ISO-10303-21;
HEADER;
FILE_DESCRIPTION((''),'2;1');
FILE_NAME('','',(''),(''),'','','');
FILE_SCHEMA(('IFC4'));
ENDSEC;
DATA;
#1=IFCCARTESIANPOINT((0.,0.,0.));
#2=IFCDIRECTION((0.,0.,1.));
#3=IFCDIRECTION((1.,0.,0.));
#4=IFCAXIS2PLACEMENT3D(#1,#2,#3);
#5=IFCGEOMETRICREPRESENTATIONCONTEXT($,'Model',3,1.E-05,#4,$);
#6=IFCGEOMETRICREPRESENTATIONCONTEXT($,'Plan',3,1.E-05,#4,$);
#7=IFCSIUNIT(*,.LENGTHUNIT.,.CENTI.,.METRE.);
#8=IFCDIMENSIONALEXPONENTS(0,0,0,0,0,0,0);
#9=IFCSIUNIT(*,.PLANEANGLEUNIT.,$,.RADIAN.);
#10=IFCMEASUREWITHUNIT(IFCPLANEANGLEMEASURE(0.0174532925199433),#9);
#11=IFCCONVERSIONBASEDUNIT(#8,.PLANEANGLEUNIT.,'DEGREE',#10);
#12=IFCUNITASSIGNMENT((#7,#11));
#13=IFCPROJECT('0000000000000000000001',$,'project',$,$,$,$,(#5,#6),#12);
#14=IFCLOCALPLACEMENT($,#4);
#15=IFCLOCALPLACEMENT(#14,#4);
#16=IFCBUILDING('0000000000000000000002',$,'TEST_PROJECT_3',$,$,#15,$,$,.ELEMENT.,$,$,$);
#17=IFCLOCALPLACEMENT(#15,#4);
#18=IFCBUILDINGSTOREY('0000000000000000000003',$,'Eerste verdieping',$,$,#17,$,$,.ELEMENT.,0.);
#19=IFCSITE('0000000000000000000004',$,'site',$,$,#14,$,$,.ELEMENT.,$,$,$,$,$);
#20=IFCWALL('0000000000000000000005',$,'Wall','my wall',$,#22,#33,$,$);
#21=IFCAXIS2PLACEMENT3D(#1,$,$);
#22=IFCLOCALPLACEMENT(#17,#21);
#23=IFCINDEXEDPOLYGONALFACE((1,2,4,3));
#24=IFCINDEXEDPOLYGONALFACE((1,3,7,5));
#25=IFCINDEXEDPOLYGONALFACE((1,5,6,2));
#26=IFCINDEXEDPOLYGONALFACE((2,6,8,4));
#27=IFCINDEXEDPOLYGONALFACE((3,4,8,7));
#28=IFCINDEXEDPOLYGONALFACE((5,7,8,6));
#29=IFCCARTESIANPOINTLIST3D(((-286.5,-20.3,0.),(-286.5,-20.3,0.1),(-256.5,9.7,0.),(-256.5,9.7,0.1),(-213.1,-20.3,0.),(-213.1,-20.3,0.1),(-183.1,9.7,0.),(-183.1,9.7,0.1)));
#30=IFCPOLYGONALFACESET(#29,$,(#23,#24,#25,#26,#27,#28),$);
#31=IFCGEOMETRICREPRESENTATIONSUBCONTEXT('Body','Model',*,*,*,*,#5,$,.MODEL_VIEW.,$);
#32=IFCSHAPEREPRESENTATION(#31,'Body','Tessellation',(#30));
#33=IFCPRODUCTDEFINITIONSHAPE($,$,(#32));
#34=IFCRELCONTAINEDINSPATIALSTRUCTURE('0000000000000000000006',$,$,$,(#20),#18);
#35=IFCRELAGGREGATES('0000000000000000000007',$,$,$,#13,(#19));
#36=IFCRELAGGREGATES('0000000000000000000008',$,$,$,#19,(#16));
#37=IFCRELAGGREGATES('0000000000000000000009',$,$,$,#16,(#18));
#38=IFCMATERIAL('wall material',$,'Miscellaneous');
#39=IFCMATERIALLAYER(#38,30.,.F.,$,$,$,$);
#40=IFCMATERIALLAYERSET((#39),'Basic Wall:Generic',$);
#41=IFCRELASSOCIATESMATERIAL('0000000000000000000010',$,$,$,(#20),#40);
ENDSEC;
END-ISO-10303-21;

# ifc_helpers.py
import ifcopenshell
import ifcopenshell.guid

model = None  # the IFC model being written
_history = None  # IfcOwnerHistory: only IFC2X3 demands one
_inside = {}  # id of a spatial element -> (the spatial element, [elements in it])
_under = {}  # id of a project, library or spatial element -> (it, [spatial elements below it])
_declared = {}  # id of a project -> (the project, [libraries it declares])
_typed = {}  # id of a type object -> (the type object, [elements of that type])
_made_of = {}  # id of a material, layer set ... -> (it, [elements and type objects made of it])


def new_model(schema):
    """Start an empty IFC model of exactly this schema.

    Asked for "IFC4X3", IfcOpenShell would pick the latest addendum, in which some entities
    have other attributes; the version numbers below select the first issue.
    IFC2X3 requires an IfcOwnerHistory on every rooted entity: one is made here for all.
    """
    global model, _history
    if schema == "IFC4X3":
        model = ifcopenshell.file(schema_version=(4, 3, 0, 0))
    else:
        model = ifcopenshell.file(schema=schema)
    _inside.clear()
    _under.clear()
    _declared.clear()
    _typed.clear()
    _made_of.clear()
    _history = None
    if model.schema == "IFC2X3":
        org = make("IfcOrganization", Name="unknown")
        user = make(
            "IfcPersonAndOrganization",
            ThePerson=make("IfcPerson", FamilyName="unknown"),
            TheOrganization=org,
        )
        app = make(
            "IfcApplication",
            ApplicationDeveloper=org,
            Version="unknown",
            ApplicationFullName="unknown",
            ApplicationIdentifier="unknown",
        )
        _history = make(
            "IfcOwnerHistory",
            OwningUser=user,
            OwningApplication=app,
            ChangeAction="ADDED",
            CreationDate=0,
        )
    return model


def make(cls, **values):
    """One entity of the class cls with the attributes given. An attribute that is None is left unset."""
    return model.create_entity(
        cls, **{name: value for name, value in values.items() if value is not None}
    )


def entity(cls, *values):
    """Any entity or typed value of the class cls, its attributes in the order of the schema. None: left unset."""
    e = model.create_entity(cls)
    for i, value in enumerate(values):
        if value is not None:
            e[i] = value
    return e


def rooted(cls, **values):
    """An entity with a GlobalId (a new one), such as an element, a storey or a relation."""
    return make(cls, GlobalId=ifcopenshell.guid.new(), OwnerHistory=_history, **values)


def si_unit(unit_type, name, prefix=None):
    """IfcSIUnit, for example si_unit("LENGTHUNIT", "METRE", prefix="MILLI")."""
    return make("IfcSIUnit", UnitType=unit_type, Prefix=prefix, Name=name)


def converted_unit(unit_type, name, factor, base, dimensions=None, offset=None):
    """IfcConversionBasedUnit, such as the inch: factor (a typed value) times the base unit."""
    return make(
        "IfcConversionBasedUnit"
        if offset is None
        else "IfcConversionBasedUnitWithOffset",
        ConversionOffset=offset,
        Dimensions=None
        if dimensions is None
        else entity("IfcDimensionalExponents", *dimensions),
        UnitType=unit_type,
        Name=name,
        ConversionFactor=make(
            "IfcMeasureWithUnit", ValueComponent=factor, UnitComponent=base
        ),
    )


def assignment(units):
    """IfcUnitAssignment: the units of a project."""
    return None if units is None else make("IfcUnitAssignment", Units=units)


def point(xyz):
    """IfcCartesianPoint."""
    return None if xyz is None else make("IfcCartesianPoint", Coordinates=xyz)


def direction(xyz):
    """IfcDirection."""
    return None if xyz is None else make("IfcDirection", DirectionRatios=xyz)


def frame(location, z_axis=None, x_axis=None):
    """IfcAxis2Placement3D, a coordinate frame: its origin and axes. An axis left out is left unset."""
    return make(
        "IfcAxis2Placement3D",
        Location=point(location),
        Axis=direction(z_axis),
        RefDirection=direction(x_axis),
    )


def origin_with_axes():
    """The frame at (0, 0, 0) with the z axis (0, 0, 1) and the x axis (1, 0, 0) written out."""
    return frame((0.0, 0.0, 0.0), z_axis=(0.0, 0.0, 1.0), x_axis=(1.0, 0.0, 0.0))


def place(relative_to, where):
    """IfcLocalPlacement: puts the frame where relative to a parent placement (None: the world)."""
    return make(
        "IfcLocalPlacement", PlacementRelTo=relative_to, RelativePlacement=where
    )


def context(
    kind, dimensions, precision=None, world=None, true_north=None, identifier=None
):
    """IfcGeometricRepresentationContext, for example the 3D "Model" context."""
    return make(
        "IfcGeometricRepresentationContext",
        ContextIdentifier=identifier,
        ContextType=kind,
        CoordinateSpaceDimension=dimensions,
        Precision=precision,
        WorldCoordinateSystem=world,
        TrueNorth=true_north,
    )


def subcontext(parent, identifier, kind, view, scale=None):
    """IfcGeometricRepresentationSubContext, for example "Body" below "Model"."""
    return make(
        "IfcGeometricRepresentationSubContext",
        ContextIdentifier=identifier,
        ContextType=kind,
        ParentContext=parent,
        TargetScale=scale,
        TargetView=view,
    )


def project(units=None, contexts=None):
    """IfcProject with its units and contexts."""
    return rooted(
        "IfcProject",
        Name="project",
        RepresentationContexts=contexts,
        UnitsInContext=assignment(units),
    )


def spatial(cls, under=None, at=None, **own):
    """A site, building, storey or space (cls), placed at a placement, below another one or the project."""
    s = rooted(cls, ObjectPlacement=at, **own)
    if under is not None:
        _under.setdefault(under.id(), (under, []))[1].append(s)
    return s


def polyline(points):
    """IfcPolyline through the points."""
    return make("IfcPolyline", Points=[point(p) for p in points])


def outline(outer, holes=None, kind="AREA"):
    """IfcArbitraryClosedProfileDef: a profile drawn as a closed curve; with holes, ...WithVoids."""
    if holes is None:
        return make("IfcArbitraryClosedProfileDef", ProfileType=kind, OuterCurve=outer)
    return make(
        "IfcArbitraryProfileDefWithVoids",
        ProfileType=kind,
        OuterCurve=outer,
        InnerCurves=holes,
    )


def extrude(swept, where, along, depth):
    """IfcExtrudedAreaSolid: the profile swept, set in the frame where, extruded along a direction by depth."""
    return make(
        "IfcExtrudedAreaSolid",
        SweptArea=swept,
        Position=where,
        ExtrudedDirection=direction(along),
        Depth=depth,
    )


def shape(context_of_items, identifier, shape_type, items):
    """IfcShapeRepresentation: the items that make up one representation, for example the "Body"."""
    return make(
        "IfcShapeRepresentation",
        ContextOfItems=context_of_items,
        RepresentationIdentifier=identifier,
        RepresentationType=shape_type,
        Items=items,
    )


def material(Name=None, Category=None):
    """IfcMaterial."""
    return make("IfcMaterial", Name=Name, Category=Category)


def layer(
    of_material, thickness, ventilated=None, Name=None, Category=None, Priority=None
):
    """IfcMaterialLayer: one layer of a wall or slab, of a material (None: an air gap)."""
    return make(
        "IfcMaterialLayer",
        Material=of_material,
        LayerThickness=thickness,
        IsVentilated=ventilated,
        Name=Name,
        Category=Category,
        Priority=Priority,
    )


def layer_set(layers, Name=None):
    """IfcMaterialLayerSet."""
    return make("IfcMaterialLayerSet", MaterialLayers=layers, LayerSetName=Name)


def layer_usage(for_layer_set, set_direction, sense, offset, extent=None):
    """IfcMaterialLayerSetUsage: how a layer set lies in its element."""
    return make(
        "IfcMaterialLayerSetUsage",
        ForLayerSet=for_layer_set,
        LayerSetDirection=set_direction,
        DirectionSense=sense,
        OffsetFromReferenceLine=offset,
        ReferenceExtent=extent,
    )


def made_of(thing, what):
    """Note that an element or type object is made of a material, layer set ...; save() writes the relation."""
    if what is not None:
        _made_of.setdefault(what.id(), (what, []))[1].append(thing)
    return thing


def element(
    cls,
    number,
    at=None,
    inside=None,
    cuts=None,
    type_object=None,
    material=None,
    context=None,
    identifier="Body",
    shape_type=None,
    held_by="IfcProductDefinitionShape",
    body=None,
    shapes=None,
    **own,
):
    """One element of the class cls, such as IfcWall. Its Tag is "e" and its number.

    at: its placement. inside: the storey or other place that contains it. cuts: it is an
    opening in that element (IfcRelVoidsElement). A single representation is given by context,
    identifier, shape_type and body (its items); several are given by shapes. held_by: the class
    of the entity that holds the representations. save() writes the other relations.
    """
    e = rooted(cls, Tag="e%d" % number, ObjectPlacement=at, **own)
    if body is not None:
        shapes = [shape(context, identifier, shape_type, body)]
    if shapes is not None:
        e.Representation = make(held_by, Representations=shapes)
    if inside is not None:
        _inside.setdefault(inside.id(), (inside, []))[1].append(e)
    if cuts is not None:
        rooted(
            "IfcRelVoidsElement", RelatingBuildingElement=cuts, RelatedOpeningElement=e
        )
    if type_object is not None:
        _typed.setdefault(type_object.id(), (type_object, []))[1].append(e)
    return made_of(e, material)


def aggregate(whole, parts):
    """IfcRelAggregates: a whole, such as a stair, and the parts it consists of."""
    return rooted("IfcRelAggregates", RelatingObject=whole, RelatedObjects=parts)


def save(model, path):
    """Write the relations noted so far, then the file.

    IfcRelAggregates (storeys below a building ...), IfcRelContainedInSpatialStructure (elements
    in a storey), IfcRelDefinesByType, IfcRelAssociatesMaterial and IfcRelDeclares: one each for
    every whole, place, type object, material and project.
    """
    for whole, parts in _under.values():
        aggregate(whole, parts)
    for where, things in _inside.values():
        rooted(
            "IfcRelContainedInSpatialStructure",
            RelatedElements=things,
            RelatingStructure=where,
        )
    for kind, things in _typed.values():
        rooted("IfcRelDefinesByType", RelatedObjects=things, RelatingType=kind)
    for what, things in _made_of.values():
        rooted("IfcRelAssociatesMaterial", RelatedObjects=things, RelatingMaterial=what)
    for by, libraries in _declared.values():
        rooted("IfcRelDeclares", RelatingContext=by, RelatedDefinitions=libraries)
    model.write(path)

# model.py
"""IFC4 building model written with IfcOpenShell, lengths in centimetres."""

from ifc_helpers import new_model, entity, si_unit, converted_unit, origin_with_axes, place, context, subcontext, project, spatial, polyline, outline, extrude, material, layer, layer_set, layer_usage, element, save


model = new_model("IFC4")

# Units and contexts
model_context = context("Model", 3, precision=1e-05, world=origin_with_axes())
plan_context = context("Plan", 3, precision=1e-05, world=origin_with_axes())
body_context = subcontext(model_context, "Body", "Model", "MODEL_VIEW")
ifc_project = project(units=[si_unit("LENGTHUNIT", "METRE", prefix="CENTI"), converted_unit("PLANEANGLEUNIT", "DEGREE", entity("IfcPlaneAngleMeasure", 0.0174532925199433), si_unit("PLANEANGLEUNIT", "RADIAN"), dimensions=[0, 0, 0, 0, 0, 0, 0])], contexts=[model_context, plan_context])

# Site, building, storey
site_placement = place(None, origin_with_axes())
site = spatial("IfcSite", under=ifc_project, at=site_placement, Name="site", CompositionType="ELEMENT")
building_placement = place(site_placement, origin_with_axes())
building = spatial("IfcBuilding", under=site, at=building_placement, Name="TEST_PROJECT_3", CompositionType="ELEMENT")
storey_placement = place(building_placement, origin_with_axes())
storey = spatial("IfcBuildingStorey", under=building, at=storey_placement, Name="Eerste verdieping", CompositionType="ELEMENT", Elevation=0.0)

# Wall
ifc_material_1 = material(Name="wall material", Category="Miscellaneous")
ifc_layer_1 = layer(ifc_material_1, 30.0, ventilated=False)
ifc_layer_set_1 = layer_set([ifc_layer_1], Name="Basic Wall:Generic")
ifc_layer_usage_1 = layer_usage(ifc_layer_set_1, "AXIS3", "NEGATIVE", 0.0)
wall_1_placement = place(storey_placement, origin_with_axes())
element("IfcWall", 1, at=wall_1_placement, inside=storey, material=ifc_layer_usage_1, Name="Wall", Description="my wall", context=body_context, shape_type="SweptSolid", body=[
    extrude(outline(polyline([(-286.5, -20.3, 0.0), (-256.5, 9.7, 0.0), (-183.1, 9.7, 0.0), (-213.1, -20.3, 0.0), (-286.5, -20.3, 0.0)])), origin_with_axes(), (0.0, 0.0, 1.0), 0.1),
])

save(model, "model.ifc")
